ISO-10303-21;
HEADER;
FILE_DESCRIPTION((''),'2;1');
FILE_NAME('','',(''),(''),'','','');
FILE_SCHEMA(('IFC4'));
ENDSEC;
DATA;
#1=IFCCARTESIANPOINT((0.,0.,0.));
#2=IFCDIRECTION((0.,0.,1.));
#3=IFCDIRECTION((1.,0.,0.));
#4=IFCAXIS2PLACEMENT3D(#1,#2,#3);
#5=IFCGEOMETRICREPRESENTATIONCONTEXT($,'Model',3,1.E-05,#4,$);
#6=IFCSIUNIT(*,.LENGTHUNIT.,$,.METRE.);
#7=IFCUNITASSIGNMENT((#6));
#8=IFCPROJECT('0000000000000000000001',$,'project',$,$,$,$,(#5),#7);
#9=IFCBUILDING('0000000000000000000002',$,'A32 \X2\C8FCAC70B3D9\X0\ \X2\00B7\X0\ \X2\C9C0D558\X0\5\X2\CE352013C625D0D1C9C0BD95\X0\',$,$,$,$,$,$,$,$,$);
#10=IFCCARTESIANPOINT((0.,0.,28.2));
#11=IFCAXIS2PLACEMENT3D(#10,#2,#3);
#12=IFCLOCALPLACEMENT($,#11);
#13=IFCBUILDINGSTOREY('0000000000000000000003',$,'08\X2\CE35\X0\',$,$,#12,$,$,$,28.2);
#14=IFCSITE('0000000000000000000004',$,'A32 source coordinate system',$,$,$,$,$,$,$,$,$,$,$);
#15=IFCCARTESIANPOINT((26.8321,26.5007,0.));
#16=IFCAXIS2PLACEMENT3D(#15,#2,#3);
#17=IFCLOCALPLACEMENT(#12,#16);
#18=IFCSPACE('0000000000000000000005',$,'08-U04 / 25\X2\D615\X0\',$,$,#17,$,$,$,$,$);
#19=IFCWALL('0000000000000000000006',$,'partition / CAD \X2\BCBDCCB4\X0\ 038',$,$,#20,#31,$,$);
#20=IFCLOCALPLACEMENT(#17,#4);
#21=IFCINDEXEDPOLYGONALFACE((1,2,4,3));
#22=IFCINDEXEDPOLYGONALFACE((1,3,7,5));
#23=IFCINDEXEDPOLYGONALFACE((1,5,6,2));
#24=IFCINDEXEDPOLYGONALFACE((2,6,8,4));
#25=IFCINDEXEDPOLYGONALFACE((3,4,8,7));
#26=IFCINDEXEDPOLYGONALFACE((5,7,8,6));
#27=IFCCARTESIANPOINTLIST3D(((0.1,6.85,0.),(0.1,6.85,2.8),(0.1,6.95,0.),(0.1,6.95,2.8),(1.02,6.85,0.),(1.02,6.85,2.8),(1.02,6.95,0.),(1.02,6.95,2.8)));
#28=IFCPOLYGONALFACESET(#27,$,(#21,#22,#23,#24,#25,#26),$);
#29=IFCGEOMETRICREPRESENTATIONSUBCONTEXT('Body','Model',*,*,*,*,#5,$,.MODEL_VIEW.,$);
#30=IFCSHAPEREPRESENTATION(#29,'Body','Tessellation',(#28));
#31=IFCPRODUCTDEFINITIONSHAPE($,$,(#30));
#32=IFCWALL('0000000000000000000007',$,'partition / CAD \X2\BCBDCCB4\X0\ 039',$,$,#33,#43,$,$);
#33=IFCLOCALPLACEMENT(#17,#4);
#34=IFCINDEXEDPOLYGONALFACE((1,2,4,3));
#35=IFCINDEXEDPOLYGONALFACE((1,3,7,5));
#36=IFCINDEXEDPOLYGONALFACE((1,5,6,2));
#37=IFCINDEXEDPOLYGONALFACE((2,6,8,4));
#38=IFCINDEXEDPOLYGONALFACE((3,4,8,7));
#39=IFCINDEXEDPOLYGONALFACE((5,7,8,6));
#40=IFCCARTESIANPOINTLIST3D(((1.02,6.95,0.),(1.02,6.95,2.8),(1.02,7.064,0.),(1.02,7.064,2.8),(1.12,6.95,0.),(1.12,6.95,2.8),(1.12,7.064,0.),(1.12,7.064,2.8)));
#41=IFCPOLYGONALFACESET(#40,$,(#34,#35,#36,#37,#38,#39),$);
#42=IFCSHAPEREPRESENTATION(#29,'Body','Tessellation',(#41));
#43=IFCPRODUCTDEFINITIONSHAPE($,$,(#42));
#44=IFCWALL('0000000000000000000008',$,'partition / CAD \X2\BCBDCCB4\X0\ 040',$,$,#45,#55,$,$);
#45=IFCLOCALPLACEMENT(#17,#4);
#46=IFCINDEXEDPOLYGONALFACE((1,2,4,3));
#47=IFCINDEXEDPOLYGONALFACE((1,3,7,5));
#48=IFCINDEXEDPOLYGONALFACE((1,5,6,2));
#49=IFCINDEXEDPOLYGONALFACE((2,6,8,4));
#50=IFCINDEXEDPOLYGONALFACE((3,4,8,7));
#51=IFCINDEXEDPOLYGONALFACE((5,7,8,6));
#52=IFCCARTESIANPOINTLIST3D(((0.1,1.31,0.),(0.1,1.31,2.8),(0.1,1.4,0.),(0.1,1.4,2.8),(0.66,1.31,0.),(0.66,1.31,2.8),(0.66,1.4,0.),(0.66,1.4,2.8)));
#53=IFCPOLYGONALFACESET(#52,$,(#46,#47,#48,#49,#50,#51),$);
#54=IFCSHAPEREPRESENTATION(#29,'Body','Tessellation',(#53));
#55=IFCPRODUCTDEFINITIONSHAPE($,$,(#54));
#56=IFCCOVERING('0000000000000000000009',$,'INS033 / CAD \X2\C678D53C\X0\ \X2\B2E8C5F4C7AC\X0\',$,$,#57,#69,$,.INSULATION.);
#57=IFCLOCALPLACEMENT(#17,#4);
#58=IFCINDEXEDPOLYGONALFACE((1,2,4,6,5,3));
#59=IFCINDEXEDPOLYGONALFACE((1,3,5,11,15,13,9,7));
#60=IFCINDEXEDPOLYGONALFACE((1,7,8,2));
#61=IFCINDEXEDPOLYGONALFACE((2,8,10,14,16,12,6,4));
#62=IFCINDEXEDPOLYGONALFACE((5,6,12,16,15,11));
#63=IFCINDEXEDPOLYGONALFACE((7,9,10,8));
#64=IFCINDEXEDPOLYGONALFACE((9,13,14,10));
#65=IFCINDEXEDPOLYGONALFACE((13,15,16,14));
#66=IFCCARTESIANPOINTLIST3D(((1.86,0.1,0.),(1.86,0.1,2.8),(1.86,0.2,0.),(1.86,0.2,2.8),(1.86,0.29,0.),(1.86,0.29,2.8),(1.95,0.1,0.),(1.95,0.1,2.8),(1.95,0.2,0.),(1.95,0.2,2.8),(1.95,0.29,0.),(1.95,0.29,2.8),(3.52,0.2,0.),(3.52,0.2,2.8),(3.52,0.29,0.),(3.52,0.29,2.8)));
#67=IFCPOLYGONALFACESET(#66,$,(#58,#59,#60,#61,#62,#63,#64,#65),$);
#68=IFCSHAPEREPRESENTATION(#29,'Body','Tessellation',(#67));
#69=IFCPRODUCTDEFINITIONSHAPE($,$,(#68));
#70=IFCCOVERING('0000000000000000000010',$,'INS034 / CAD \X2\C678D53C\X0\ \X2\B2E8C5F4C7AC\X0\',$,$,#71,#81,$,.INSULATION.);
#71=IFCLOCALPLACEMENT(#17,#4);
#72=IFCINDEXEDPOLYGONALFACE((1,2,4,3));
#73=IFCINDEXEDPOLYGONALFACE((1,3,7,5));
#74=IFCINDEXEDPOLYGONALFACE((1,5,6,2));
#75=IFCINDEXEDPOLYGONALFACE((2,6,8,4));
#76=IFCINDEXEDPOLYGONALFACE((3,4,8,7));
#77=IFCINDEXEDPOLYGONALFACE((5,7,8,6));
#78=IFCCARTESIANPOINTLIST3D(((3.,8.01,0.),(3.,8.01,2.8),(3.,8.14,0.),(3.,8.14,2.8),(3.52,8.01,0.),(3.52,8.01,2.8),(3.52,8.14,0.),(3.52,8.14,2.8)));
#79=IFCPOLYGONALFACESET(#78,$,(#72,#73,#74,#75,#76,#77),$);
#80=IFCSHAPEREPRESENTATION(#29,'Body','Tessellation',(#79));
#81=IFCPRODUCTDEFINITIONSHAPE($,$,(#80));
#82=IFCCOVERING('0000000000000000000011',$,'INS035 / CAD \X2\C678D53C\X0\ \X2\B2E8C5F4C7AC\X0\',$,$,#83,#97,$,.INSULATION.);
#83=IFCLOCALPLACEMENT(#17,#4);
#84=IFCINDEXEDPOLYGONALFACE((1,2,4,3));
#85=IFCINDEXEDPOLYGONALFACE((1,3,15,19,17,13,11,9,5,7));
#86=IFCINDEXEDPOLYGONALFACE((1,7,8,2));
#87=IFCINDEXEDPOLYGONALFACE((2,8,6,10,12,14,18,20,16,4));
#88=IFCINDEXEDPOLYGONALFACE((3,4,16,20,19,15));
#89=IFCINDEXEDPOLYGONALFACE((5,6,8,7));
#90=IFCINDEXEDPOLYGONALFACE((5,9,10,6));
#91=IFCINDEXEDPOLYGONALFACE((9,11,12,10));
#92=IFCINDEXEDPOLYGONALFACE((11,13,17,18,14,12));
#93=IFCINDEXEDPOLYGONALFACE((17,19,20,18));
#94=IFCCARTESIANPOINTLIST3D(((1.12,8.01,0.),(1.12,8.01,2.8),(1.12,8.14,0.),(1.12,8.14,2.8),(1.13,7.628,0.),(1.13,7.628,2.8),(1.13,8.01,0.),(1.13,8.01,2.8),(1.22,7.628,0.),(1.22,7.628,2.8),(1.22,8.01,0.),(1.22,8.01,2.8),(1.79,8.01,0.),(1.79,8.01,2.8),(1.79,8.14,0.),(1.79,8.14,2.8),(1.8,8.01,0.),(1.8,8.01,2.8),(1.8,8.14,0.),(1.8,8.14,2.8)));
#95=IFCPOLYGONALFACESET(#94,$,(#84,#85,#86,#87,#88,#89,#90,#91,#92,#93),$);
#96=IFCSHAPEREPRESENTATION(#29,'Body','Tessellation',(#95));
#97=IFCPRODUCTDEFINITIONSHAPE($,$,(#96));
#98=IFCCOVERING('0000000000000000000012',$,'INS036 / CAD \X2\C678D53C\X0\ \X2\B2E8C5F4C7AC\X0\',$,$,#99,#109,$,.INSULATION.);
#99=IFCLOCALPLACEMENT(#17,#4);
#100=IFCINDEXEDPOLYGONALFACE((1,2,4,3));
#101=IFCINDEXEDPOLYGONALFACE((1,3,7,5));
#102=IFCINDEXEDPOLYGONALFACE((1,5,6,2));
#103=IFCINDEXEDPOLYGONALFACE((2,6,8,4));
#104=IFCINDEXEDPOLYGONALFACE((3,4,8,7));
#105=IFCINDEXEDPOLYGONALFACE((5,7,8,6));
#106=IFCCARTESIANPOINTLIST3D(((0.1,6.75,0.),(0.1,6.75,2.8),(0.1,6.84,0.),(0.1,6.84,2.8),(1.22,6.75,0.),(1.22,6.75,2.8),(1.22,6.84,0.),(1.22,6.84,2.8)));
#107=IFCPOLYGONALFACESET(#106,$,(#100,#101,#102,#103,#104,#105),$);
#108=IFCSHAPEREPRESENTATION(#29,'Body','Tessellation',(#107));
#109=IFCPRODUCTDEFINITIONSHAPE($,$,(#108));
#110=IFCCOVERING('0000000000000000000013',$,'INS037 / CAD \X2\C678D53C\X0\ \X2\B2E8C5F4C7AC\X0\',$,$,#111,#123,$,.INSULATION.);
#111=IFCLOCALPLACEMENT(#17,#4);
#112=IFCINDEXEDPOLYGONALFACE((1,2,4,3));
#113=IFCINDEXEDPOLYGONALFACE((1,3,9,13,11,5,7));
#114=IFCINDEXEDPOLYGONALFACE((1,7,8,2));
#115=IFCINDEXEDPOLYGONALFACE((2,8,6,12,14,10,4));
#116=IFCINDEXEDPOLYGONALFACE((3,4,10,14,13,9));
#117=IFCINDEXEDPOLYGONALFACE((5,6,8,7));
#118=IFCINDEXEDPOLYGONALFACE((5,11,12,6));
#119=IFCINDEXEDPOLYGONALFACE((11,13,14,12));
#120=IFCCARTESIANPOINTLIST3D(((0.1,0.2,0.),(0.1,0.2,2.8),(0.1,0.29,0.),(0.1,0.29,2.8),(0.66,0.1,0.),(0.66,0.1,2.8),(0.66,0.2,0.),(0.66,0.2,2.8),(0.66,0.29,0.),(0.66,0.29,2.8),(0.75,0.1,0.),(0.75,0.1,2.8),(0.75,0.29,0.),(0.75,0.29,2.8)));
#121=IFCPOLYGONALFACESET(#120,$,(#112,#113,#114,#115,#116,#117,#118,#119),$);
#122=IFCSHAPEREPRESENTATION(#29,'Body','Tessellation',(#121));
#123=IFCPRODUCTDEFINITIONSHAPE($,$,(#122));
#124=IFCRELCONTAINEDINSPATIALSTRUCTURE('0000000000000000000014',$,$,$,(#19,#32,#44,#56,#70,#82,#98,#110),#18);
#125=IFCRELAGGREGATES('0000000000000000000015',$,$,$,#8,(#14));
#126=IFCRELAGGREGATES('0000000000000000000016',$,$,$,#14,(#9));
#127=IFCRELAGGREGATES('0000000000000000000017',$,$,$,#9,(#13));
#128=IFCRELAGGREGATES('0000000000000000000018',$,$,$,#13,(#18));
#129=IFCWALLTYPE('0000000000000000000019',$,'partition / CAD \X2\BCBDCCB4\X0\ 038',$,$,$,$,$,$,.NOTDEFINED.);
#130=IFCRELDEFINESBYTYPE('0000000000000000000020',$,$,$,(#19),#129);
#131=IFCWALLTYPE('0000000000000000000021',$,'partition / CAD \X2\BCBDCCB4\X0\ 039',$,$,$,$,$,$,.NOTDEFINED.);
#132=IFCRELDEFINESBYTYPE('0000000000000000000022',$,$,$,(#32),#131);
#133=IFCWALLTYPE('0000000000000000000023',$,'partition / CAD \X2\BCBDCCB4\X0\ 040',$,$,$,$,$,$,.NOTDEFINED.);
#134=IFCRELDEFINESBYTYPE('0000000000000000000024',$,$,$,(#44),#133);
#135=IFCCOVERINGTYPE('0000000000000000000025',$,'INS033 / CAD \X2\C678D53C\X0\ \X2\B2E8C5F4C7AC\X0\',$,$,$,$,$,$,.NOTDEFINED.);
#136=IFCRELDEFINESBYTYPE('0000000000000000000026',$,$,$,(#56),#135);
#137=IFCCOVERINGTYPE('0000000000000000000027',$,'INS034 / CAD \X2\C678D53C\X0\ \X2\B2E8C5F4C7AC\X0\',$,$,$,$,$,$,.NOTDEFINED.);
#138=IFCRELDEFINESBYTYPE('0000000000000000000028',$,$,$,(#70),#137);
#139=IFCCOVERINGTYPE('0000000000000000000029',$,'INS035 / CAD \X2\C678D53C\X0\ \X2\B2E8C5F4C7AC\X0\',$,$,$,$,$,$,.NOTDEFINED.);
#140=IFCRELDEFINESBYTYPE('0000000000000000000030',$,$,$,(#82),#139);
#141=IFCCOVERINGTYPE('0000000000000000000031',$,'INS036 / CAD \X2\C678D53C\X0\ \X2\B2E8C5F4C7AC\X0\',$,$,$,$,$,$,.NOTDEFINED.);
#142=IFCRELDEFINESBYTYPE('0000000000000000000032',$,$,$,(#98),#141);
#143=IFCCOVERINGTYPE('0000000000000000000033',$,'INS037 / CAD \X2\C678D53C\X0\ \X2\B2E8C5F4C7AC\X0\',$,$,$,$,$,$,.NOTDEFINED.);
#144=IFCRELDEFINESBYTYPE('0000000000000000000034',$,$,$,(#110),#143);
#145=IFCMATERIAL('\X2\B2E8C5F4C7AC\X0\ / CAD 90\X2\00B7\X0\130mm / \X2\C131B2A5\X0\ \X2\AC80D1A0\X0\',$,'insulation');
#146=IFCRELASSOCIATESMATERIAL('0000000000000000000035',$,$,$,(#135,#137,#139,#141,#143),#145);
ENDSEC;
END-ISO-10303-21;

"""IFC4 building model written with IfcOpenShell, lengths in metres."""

from ifc_helpers import new_model, si_unit, frame, origin, origin_with_axes, place, context, subcontext, project, spatial, polyline, outline, extrude, source, transform, mapped, material, type_object, type_shapes, element, save


model = new_model("IFC4")

# Units and contexts
model_context = context("Model", 3, precision=1e-05, world=origin_with_axes())
body_context = subcontext(model_context, "Body", "Model", "MODEL_VIEW")
ifc_project = project(units=[si_unit("LENGTHUNIT", "METRE")], contexts=[model_context])

# Site, building, storey, space
storey_placement = place(None, frame((0.0, 0.0, 28.2), z_axis=(0.0, 0.0, 1.0), x_axis=(1.0, 0.0, 0.0)))
space_placement = place(storey_placement, frame((26.8321, 26.5007, 0.0), z_axis=(0.0, 0.0, 1.0), x_axis=(1.0, 0.0, 0.0)))
site = spatial("IfcSite", under=ifc_project, Name="A32 source coordinate system")
building = spatial("IfcBuilding", under=site, Name="A32 주거동 · 지하5층–옥탑지붕")
storey = spatial("IfcBuildingStorey", under=building, at=storey_placement, Name="08층", Elevation=28.2)
space = spatial("IfcSpace", under=storey, at=space_placement, Name="08-U04 / 25형")

# Walls
wall_type_1 = type_object("IfcWallType", Name="partition / CAD 벽체 038", PredefinedType="NOTDEFINED")
shared_shape_1 = source(origin(), body_context, "Body", "SweptSolid", [
    extrude(outline(polyline([(0.1, 6.95), (1.02, 6.95), (1.02, 6.85), (0.1, 6.85), (0.1, 6.95)])), origin(), (0.0, 0.0, 1.0), 2.8),
])
type_shapes(wall_type_1, [shared_shape_1])
wall_1_placement = place(space_placement, origin_with_axes())
element("IfcWall", 1, at=wall_1_placement, inside=space, type_object=wall_type_1, Name="partition / CAD 벽체 038", context=body_context, shape_type="MappedRepresentation", body=[
    mapped(shared_shape_1, transform((0.0, 0.0, 0.0), scale=1.0)),
])
wall_type_2 = type_object("IfcWallType", Name="partition / CAD 벽체 039", PredefinedType="NOTDEFINED")
shared_shape_2 = source(origin(), body_context, "Body", "SweptSolid", [
    extrude(outline(polyline([(1.02, 6.95), (1.02, 7.064), (1.12, 7.064), (1.12, 6.95), (1.02, 6.95)])), origin(), (0.0, 0.0, 1.0), 2.8),
])
type_shapes(wall_type_2, [shared_shape_2])
wall_2_placement = place(space_placement, origin_with_axes())
element("IfcWall", 2, at=wall_2_placement, inside=space, type_object=wall_type_2, Name="partition / CAD 벽체 039", context=body_context, shape_type="MappedRepresentation", body=[
    mapped(shared_shape_2, transform((0.0, 0.0, 0.0), scale=1.0)),
])
wall_type_3 = type_object("IfcWallType", Name="partition / CAD 벽체 040", PredefinedType="NOTDEFINED")
shared_shape_3 = source(origin(), body_context, "Body", "SweptSolid", [
    extrude(outline(polyline([(0.1, 1.4), (0.66, 1.4), (0.66, 1.31), (0.1, 1.31), (0.1, 1.4)])), origin(), (0.0, 0.0, 1.0), 2.8),
])
type_shapes(wall_type_3, [shared_shape_3])
wall_3_placement = place(space_placement, origin_with_axes())
element("IfcWall", 3, at=wall_3_placement, inside=space, type_object=wall_type_3, Name="partition / CAD 벽체 040", context=body_context, shape_type="MappedRepresentation", body=[
    mapped(shared_shape_3, transform((0.0, 0.0, 0.0), scale=1.0)),
])

# Coverings
ifc_material = material(Name="단열재 / CAD 90·130mm / 성능 검토", Category="insulation")
covering_type_1 = type_object("IfcCoveringType", Name="INS033 / CAD 외피 단열재", PredefinedType="NOTDEFINED", material=ifc_material)
shared_shape_4 = source(origin(), body_context, "Body", "SweptSolid", [
    extrude(outline(polyline([(1.95, 0.29), (3.52, 0.29), (3.52, 0.2), (1.95, 0.2), (1.95, 0.1), (1.86, 0.1), (1.86, 0.2), (1.86, 0.29), (1.95, 0.29)])), origin(), (0.0, 0.0, 1.0), 2.8),
])
type_shapes(covering_type_1, [shared_shape_4])
covering_1_placement = place(space_placement, origin_with_axes())
element("IfcCovering", 4, at=covering_1_placement, inside=space, type_object=covering_type_1, Name="INS033 / CAD 외피 단열재", PredefinedType="INSULATION", context=body_context, shape_type="MappedRepresentation", body=[
    mapped(shared_shape_4, transform((0.0, 0.0, 0.0), scale=1.0)),
])
covering_type_2 = type_object("IfcCoveringType", Name="INS034 / CAD 외피 단열재", PredefinedType="NOTDEFINED", material=ifc_material)
shared_shape_5 = source(origin(), body_context, "Body", "SweptSolid", [
    extrude(outline(polyline([(3.52, 8.01), (3.0, 8.01), (3.0, 8.14), (3.52, 8.14), (3.52, 8.01)])), origin(), (0.0, 0.0, 1.0), 2.8),
])
type_shapes(covering_type_2, [shared_shape_5])
covering_2_placement = place(space_placement, origin_with_axes())
element("IfcCovering", 5, at=covering_2_placement, inside=space, type_object=covering_type_2, Name="INS034 / CAD 외피 단열재", PredefinedType="INSULATION", context=body_context, shape_type="MappedRepresentation", body=[
    mapped(shared_shape_5, transform((0.0, 0.0, 0.0), scale=1.0)),
])
covering_type_3 = type_object("IfcCoveringType", Name="INS035 / CAD 외피 단열재", PredefinedType="NOTDEFINED", material=ifc_material)
shared_shape_6 = source(origin(), body_context, "Body", "SweptSolid", [
    extrude(outline(polyline([(1.8, 8.01), (1.79, 8.01), (1.22, 8.01), (1.22, 7.628), (1.13, 7.628), (1.13, 8.01), (1.12, 8.01), (1.12, 8.14), (1.79, 8.14), (1.8, 8.14), (1.8, 8.01)])), origin(), (0.0, 0.0, 1.0), 2.8),
])
type_shapes(covering_type_3, [shared_shape_6])
covering_3_placement = place(space_placement, origin_with_axes())
element("IfcCovering", 6, at=covering_3_placement, inside=space, type_object=covering_type_3, Name="INS035 / CAD 외피 단열재", PredefinedType="INSULATION", context=body_context, shape_type="MappedRepresentation", body=[
    mapped(shared_shape_6, transform((0.0, 0.0, 0.0), scale=1.0)),
])
covering_type_4 = type_object("IfcCoveringType", Name="INS036 / CAD 외피 단열재", PredefinedType="NOTDEFINED", material=ifc_material)
shared_shape_7 = source(origin(), body_context, "Body", "SweptSolid", [
    extrude(outline(polyline([(1.22, 6.84), (1.22, 6.75), (0.1, 6.75), (0.1, 6.84), (1.22, 6.84)])), origin(), (0.0, 0.0, 1.0), 2.8),
])
type_shapes(covering_type_4, [shared_shape_7])
covering_4_placement = place(space_placement, origin_with_axes())
element("IfcCovering", 7, at=covering_4_placement, inside=space, type_object=covering_type_4, Name="INS036 / CAD 외피 단열재", PredefinedType="INSULATION", context=body_context, shape_type="MappedRepresentation", body=[
    mapped(shared_shape_7, transform((0.0, 0.0, 0.0), scale=1.0)),
])
covering_type_5 = type_object("IfcCoveringType", Name="INS037 / CAD 외피 단열재", PredefinedType="NOTDEFINED", material=ifc_material)
shared_shape_8 = source(origin(), body_context, "Body", "SweptSolid", [
    extrude(outline(polyline([(0.1, 0.2), (0.1, 0.29), (0.66, 0.29), (0.75, 0.29), (0.75, 0.1), (0.66, 0.1), (0.66, 0.2), (0.1, 0.2)])), origin(), (0.0, 0.0, 1.0), 2.8),
])
type_shapes(covering_type_5, [shared_shape_8])
covering_5_placement = place(space_placement, origin_with_axes())
element("IfcCovering", 8, at=covering_5_placement, inside=space, type_object=covering_type_5, Name="INS037 / CAD 외피 단열재", PredefinedType="INSULATION", context=body_context, shape_type="MappedRepresentation", body=[
    mapped(shared_shape_8, transform((0.0, 0.0, 0.0), scale=1.0)),
])

save(model, "model.ifc")
